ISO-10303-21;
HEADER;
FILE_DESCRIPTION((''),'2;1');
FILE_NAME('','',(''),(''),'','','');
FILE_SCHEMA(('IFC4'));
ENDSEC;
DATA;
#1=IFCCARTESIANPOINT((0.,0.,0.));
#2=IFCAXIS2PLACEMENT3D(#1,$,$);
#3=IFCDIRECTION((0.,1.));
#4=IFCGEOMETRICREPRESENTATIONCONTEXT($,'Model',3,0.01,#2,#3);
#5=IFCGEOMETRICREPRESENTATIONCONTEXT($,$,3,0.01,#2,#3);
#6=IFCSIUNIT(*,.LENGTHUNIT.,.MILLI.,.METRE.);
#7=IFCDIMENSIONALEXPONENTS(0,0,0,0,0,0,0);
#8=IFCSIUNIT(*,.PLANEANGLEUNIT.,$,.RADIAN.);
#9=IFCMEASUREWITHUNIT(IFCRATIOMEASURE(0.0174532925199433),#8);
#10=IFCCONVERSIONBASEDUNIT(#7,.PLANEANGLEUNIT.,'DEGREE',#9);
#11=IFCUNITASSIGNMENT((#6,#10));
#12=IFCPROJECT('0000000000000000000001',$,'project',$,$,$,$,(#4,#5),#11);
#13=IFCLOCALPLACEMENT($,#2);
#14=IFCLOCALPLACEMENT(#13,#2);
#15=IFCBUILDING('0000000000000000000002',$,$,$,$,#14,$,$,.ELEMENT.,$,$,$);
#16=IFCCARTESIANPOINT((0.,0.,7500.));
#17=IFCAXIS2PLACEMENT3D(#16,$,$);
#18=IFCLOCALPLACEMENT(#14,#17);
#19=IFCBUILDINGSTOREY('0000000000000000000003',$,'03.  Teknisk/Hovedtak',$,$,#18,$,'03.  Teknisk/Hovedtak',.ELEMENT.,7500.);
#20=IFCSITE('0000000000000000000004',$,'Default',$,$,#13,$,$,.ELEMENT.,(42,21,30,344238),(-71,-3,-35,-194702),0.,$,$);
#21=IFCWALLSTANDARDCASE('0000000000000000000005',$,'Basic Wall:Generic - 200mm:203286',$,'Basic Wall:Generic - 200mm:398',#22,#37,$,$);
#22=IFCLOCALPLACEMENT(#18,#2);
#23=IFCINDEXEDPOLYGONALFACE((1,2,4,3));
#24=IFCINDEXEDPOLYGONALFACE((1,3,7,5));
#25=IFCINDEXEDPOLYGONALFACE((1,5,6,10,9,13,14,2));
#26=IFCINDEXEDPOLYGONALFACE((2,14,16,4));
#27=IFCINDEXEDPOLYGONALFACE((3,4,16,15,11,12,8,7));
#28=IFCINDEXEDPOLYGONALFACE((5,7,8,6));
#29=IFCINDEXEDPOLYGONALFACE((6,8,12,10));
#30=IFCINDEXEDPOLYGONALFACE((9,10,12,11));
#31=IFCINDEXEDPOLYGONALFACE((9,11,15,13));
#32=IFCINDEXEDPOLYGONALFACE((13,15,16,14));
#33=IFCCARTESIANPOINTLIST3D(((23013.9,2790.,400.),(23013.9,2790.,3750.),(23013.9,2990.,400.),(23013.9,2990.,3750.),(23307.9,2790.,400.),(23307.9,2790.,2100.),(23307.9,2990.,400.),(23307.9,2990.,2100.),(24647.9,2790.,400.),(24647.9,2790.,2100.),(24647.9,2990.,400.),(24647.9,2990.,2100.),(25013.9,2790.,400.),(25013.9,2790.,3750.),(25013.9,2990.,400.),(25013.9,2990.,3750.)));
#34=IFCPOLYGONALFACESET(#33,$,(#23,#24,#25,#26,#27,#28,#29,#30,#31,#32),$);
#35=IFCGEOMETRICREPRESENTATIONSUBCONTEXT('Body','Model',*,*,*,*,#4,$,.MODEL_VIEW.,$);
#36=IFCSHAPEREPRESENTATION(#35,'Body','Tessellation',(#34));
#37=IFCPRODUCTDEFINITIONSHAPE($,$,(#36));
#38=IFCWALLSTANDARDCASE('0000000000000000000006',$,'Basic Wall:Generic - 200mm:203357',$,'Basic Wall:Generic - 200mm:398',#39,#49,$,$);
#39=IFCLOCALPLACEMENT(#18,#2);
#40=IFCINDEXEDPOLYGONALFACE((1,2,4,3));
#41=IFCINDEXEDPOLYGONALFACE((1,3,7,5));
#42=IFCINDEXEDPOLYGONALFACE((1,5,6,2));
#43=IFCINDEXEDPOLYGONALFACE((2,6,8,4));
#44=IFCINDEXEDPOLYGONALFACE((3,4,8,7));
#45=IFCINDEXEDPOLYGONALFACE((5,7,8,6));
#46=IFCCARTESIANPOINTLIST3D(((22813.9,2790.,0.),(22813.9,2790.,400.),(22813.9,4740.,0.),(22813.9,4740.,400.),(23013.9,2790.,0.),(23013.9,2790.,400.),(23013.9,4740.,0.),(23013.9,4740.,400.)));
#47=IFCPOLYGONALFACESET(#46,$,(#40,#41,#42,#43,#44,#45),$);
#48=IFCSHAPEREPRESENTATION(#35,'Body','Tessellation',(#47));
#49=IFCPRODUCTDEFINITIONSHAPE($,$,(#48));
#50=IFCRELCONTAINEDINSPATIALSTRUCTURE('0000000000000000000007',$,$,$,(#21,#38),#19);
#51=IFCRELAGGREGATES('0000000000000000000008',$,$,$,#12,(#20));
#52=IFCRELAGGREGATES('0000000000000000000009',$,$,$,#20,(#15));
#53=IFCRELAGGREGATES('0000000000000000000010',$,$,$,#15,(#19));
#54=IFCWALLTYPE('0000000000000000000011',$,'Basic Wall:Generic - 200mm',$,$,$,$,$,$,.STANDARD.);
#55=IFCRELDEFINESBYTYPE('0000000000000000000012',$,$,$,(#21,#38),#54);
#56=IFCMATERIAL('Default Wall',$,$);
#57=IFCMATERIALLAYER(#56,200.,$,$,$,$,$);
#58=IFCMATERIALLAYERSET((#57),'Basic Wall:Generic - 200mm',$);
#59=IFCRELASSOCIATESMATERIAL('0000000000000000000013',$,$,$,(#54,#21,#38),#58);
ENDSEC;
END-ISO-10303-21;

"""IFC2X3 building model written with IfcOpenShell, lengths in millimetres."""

from ifc_helpers import new_model, entity, si_unit, converted_unit, direction, frame, frame_2d, origin, place, context, subcontext, project, spatial, rectangle, extrude, clip, halfspace, material, layer, layer_set, layer_usage, type_object, element, save


model = new_model("IFC2X3")

# Units and contexts
model_context = context("Model", 3, precision=0.01, world=origin(), true_north=direction((0.0, 1.0)))
context_of_model = context(None, 3, precision=0.01, world=origin(), true_north=direction((0.0, 1.0)))
body_context = subcontext(model_context, "Body", "Model", "MODEL_VIEW")
ifc_project = project(units=[si_unit("LENGTHUNIT", "METRE", prefix="MILLI"), converted_unit("PLANEANGLEUNIT", "DEGREE", entity("IfcRatioMeasure", 0.0174532925199433), si_unit("PLANEANGLEUNIT", "RADIAN"), dimensions=[0, 0, 0, 0, 0, 0, 0])], contexts=[model_context, context_of_model])

# Site, building, storey
site_placement = place(None, origin())
site = spatial("IfcSite", under=ifc_project, at=site_placement, Name="Default", CompositionType="ELEMENT", RefLatitude=(42, 21, 30, 344238), RefLongitude=(-71, -3, -35, -194702), RefElevation=0.0)
building_placement = place(site_placement, origin())
building = spatial("IfcBuilding", under=site, at=building_placement, CompositionType="ELEMENT")
storey_placement = place(building_placement, frame((0.0, 0.0, 7500.0)))
storey = spatial("IfcBuildingStorey", under=building, at=storey_placement, Name="03.  Teknisk/Hovedtak", LongName="03.  Teknisk/Hovedtak", CompositionType="ELEMENT", Elevation=7500.0)

# Shared definitions
ifc_material_1 = material(Name="Default Wall")
ifc_layer_1 = layer(ifc_material_1, 200.0)
ifc_layer_set_1 = layer_set([ifc_layer_1], Name="Basic Wall:Generic - 200mm")
wall_type_1 = type_object("IfcWallType", Name="Basic Wall:Generic - 200mm", PredefinedType="STANDARD", material=ifc_layer_set_1)

# Wall, opening
ifc_layer_usage_1 = layer_usage(ifc_layer_set_1, "AXIS2", "NEGATIVE", 100.0)
wall_1_placement = place(storey_placement, frame((23013.9, 2890.0, 400.0)))
wall_1 = element("IfcWallStandardCase", 1, at=wall_1_placement, inside=storey, type_object=wall_type_1, material=ifc_layer_usage_1, Name="Basic Wall:Generic - 200mm:203286", ObjectType="Basic Wall:Generic - 200mm:398", context=body_context, shape_type="SweptSolid", body=[
    extrude(rectangle(XDim=2000.0, YDim=200.0, at=frame_2d((1000.0, 0.0), x_axis=(-1.0, 0.0))), origin(), (0.0, 0.0, 1.0), 3350.0),
])
opening_1_placement = place(wall_1_placement, frame((294.0, -1624.0, -400.0)))
element("IfcOpeningElement", 2, at=opening_1_placement, cuts=wall_1, ObjectType="Opening", context=body_context, shape_type="SweptSolid", body=[
    extrude(rectangle(XDim=2100.0, YDim=1340.0, at=frame_2d((0.0, 0.0), x_axis=(1.0, 0.0))), frame((670.0, 0.0, 1050.0), z_axis=(0.0, 1.0, 0.0), x_axis=(0.0, 0.0, -1.0)), (0.0, 0.0, 1.0), 3048.0),
])

# Wall
ifc_layer_usage_2 = layer_usage(ifc_layer_set_1, "AXIS2", "NEGATIVE", 100.0)
wall_2_placement = place(storey_placement, frame((22913.9, 4740.0, 0.0), z_axis=(0.0, 0.0, 1.0), x_axis=(0.0, -1.0, 0.0)))
element("IfcWallStandardCase", 3, at=wall_2_placement, inside=storey, type_object=wall_type_1, material=ifc_layer_usage_2, Name="Basic Wall:Generic - 200mm:203357", ObjectType="Basic Wall:Generic - 200mm:398", context=body_context, shape_type="Clipping", body=[
    clip(extrude(rectangle(XDim=1950.0, YDim=200.0, at=frame_2d((975.0, 0.0), x_axis=(-1.0, 0.0))), origin(), (0.0, 0.0, 1.0), 400.0), halfspace(frame((0.0, 0.0, -3750.0)), True)),
])

save(model, "model.ifc")
